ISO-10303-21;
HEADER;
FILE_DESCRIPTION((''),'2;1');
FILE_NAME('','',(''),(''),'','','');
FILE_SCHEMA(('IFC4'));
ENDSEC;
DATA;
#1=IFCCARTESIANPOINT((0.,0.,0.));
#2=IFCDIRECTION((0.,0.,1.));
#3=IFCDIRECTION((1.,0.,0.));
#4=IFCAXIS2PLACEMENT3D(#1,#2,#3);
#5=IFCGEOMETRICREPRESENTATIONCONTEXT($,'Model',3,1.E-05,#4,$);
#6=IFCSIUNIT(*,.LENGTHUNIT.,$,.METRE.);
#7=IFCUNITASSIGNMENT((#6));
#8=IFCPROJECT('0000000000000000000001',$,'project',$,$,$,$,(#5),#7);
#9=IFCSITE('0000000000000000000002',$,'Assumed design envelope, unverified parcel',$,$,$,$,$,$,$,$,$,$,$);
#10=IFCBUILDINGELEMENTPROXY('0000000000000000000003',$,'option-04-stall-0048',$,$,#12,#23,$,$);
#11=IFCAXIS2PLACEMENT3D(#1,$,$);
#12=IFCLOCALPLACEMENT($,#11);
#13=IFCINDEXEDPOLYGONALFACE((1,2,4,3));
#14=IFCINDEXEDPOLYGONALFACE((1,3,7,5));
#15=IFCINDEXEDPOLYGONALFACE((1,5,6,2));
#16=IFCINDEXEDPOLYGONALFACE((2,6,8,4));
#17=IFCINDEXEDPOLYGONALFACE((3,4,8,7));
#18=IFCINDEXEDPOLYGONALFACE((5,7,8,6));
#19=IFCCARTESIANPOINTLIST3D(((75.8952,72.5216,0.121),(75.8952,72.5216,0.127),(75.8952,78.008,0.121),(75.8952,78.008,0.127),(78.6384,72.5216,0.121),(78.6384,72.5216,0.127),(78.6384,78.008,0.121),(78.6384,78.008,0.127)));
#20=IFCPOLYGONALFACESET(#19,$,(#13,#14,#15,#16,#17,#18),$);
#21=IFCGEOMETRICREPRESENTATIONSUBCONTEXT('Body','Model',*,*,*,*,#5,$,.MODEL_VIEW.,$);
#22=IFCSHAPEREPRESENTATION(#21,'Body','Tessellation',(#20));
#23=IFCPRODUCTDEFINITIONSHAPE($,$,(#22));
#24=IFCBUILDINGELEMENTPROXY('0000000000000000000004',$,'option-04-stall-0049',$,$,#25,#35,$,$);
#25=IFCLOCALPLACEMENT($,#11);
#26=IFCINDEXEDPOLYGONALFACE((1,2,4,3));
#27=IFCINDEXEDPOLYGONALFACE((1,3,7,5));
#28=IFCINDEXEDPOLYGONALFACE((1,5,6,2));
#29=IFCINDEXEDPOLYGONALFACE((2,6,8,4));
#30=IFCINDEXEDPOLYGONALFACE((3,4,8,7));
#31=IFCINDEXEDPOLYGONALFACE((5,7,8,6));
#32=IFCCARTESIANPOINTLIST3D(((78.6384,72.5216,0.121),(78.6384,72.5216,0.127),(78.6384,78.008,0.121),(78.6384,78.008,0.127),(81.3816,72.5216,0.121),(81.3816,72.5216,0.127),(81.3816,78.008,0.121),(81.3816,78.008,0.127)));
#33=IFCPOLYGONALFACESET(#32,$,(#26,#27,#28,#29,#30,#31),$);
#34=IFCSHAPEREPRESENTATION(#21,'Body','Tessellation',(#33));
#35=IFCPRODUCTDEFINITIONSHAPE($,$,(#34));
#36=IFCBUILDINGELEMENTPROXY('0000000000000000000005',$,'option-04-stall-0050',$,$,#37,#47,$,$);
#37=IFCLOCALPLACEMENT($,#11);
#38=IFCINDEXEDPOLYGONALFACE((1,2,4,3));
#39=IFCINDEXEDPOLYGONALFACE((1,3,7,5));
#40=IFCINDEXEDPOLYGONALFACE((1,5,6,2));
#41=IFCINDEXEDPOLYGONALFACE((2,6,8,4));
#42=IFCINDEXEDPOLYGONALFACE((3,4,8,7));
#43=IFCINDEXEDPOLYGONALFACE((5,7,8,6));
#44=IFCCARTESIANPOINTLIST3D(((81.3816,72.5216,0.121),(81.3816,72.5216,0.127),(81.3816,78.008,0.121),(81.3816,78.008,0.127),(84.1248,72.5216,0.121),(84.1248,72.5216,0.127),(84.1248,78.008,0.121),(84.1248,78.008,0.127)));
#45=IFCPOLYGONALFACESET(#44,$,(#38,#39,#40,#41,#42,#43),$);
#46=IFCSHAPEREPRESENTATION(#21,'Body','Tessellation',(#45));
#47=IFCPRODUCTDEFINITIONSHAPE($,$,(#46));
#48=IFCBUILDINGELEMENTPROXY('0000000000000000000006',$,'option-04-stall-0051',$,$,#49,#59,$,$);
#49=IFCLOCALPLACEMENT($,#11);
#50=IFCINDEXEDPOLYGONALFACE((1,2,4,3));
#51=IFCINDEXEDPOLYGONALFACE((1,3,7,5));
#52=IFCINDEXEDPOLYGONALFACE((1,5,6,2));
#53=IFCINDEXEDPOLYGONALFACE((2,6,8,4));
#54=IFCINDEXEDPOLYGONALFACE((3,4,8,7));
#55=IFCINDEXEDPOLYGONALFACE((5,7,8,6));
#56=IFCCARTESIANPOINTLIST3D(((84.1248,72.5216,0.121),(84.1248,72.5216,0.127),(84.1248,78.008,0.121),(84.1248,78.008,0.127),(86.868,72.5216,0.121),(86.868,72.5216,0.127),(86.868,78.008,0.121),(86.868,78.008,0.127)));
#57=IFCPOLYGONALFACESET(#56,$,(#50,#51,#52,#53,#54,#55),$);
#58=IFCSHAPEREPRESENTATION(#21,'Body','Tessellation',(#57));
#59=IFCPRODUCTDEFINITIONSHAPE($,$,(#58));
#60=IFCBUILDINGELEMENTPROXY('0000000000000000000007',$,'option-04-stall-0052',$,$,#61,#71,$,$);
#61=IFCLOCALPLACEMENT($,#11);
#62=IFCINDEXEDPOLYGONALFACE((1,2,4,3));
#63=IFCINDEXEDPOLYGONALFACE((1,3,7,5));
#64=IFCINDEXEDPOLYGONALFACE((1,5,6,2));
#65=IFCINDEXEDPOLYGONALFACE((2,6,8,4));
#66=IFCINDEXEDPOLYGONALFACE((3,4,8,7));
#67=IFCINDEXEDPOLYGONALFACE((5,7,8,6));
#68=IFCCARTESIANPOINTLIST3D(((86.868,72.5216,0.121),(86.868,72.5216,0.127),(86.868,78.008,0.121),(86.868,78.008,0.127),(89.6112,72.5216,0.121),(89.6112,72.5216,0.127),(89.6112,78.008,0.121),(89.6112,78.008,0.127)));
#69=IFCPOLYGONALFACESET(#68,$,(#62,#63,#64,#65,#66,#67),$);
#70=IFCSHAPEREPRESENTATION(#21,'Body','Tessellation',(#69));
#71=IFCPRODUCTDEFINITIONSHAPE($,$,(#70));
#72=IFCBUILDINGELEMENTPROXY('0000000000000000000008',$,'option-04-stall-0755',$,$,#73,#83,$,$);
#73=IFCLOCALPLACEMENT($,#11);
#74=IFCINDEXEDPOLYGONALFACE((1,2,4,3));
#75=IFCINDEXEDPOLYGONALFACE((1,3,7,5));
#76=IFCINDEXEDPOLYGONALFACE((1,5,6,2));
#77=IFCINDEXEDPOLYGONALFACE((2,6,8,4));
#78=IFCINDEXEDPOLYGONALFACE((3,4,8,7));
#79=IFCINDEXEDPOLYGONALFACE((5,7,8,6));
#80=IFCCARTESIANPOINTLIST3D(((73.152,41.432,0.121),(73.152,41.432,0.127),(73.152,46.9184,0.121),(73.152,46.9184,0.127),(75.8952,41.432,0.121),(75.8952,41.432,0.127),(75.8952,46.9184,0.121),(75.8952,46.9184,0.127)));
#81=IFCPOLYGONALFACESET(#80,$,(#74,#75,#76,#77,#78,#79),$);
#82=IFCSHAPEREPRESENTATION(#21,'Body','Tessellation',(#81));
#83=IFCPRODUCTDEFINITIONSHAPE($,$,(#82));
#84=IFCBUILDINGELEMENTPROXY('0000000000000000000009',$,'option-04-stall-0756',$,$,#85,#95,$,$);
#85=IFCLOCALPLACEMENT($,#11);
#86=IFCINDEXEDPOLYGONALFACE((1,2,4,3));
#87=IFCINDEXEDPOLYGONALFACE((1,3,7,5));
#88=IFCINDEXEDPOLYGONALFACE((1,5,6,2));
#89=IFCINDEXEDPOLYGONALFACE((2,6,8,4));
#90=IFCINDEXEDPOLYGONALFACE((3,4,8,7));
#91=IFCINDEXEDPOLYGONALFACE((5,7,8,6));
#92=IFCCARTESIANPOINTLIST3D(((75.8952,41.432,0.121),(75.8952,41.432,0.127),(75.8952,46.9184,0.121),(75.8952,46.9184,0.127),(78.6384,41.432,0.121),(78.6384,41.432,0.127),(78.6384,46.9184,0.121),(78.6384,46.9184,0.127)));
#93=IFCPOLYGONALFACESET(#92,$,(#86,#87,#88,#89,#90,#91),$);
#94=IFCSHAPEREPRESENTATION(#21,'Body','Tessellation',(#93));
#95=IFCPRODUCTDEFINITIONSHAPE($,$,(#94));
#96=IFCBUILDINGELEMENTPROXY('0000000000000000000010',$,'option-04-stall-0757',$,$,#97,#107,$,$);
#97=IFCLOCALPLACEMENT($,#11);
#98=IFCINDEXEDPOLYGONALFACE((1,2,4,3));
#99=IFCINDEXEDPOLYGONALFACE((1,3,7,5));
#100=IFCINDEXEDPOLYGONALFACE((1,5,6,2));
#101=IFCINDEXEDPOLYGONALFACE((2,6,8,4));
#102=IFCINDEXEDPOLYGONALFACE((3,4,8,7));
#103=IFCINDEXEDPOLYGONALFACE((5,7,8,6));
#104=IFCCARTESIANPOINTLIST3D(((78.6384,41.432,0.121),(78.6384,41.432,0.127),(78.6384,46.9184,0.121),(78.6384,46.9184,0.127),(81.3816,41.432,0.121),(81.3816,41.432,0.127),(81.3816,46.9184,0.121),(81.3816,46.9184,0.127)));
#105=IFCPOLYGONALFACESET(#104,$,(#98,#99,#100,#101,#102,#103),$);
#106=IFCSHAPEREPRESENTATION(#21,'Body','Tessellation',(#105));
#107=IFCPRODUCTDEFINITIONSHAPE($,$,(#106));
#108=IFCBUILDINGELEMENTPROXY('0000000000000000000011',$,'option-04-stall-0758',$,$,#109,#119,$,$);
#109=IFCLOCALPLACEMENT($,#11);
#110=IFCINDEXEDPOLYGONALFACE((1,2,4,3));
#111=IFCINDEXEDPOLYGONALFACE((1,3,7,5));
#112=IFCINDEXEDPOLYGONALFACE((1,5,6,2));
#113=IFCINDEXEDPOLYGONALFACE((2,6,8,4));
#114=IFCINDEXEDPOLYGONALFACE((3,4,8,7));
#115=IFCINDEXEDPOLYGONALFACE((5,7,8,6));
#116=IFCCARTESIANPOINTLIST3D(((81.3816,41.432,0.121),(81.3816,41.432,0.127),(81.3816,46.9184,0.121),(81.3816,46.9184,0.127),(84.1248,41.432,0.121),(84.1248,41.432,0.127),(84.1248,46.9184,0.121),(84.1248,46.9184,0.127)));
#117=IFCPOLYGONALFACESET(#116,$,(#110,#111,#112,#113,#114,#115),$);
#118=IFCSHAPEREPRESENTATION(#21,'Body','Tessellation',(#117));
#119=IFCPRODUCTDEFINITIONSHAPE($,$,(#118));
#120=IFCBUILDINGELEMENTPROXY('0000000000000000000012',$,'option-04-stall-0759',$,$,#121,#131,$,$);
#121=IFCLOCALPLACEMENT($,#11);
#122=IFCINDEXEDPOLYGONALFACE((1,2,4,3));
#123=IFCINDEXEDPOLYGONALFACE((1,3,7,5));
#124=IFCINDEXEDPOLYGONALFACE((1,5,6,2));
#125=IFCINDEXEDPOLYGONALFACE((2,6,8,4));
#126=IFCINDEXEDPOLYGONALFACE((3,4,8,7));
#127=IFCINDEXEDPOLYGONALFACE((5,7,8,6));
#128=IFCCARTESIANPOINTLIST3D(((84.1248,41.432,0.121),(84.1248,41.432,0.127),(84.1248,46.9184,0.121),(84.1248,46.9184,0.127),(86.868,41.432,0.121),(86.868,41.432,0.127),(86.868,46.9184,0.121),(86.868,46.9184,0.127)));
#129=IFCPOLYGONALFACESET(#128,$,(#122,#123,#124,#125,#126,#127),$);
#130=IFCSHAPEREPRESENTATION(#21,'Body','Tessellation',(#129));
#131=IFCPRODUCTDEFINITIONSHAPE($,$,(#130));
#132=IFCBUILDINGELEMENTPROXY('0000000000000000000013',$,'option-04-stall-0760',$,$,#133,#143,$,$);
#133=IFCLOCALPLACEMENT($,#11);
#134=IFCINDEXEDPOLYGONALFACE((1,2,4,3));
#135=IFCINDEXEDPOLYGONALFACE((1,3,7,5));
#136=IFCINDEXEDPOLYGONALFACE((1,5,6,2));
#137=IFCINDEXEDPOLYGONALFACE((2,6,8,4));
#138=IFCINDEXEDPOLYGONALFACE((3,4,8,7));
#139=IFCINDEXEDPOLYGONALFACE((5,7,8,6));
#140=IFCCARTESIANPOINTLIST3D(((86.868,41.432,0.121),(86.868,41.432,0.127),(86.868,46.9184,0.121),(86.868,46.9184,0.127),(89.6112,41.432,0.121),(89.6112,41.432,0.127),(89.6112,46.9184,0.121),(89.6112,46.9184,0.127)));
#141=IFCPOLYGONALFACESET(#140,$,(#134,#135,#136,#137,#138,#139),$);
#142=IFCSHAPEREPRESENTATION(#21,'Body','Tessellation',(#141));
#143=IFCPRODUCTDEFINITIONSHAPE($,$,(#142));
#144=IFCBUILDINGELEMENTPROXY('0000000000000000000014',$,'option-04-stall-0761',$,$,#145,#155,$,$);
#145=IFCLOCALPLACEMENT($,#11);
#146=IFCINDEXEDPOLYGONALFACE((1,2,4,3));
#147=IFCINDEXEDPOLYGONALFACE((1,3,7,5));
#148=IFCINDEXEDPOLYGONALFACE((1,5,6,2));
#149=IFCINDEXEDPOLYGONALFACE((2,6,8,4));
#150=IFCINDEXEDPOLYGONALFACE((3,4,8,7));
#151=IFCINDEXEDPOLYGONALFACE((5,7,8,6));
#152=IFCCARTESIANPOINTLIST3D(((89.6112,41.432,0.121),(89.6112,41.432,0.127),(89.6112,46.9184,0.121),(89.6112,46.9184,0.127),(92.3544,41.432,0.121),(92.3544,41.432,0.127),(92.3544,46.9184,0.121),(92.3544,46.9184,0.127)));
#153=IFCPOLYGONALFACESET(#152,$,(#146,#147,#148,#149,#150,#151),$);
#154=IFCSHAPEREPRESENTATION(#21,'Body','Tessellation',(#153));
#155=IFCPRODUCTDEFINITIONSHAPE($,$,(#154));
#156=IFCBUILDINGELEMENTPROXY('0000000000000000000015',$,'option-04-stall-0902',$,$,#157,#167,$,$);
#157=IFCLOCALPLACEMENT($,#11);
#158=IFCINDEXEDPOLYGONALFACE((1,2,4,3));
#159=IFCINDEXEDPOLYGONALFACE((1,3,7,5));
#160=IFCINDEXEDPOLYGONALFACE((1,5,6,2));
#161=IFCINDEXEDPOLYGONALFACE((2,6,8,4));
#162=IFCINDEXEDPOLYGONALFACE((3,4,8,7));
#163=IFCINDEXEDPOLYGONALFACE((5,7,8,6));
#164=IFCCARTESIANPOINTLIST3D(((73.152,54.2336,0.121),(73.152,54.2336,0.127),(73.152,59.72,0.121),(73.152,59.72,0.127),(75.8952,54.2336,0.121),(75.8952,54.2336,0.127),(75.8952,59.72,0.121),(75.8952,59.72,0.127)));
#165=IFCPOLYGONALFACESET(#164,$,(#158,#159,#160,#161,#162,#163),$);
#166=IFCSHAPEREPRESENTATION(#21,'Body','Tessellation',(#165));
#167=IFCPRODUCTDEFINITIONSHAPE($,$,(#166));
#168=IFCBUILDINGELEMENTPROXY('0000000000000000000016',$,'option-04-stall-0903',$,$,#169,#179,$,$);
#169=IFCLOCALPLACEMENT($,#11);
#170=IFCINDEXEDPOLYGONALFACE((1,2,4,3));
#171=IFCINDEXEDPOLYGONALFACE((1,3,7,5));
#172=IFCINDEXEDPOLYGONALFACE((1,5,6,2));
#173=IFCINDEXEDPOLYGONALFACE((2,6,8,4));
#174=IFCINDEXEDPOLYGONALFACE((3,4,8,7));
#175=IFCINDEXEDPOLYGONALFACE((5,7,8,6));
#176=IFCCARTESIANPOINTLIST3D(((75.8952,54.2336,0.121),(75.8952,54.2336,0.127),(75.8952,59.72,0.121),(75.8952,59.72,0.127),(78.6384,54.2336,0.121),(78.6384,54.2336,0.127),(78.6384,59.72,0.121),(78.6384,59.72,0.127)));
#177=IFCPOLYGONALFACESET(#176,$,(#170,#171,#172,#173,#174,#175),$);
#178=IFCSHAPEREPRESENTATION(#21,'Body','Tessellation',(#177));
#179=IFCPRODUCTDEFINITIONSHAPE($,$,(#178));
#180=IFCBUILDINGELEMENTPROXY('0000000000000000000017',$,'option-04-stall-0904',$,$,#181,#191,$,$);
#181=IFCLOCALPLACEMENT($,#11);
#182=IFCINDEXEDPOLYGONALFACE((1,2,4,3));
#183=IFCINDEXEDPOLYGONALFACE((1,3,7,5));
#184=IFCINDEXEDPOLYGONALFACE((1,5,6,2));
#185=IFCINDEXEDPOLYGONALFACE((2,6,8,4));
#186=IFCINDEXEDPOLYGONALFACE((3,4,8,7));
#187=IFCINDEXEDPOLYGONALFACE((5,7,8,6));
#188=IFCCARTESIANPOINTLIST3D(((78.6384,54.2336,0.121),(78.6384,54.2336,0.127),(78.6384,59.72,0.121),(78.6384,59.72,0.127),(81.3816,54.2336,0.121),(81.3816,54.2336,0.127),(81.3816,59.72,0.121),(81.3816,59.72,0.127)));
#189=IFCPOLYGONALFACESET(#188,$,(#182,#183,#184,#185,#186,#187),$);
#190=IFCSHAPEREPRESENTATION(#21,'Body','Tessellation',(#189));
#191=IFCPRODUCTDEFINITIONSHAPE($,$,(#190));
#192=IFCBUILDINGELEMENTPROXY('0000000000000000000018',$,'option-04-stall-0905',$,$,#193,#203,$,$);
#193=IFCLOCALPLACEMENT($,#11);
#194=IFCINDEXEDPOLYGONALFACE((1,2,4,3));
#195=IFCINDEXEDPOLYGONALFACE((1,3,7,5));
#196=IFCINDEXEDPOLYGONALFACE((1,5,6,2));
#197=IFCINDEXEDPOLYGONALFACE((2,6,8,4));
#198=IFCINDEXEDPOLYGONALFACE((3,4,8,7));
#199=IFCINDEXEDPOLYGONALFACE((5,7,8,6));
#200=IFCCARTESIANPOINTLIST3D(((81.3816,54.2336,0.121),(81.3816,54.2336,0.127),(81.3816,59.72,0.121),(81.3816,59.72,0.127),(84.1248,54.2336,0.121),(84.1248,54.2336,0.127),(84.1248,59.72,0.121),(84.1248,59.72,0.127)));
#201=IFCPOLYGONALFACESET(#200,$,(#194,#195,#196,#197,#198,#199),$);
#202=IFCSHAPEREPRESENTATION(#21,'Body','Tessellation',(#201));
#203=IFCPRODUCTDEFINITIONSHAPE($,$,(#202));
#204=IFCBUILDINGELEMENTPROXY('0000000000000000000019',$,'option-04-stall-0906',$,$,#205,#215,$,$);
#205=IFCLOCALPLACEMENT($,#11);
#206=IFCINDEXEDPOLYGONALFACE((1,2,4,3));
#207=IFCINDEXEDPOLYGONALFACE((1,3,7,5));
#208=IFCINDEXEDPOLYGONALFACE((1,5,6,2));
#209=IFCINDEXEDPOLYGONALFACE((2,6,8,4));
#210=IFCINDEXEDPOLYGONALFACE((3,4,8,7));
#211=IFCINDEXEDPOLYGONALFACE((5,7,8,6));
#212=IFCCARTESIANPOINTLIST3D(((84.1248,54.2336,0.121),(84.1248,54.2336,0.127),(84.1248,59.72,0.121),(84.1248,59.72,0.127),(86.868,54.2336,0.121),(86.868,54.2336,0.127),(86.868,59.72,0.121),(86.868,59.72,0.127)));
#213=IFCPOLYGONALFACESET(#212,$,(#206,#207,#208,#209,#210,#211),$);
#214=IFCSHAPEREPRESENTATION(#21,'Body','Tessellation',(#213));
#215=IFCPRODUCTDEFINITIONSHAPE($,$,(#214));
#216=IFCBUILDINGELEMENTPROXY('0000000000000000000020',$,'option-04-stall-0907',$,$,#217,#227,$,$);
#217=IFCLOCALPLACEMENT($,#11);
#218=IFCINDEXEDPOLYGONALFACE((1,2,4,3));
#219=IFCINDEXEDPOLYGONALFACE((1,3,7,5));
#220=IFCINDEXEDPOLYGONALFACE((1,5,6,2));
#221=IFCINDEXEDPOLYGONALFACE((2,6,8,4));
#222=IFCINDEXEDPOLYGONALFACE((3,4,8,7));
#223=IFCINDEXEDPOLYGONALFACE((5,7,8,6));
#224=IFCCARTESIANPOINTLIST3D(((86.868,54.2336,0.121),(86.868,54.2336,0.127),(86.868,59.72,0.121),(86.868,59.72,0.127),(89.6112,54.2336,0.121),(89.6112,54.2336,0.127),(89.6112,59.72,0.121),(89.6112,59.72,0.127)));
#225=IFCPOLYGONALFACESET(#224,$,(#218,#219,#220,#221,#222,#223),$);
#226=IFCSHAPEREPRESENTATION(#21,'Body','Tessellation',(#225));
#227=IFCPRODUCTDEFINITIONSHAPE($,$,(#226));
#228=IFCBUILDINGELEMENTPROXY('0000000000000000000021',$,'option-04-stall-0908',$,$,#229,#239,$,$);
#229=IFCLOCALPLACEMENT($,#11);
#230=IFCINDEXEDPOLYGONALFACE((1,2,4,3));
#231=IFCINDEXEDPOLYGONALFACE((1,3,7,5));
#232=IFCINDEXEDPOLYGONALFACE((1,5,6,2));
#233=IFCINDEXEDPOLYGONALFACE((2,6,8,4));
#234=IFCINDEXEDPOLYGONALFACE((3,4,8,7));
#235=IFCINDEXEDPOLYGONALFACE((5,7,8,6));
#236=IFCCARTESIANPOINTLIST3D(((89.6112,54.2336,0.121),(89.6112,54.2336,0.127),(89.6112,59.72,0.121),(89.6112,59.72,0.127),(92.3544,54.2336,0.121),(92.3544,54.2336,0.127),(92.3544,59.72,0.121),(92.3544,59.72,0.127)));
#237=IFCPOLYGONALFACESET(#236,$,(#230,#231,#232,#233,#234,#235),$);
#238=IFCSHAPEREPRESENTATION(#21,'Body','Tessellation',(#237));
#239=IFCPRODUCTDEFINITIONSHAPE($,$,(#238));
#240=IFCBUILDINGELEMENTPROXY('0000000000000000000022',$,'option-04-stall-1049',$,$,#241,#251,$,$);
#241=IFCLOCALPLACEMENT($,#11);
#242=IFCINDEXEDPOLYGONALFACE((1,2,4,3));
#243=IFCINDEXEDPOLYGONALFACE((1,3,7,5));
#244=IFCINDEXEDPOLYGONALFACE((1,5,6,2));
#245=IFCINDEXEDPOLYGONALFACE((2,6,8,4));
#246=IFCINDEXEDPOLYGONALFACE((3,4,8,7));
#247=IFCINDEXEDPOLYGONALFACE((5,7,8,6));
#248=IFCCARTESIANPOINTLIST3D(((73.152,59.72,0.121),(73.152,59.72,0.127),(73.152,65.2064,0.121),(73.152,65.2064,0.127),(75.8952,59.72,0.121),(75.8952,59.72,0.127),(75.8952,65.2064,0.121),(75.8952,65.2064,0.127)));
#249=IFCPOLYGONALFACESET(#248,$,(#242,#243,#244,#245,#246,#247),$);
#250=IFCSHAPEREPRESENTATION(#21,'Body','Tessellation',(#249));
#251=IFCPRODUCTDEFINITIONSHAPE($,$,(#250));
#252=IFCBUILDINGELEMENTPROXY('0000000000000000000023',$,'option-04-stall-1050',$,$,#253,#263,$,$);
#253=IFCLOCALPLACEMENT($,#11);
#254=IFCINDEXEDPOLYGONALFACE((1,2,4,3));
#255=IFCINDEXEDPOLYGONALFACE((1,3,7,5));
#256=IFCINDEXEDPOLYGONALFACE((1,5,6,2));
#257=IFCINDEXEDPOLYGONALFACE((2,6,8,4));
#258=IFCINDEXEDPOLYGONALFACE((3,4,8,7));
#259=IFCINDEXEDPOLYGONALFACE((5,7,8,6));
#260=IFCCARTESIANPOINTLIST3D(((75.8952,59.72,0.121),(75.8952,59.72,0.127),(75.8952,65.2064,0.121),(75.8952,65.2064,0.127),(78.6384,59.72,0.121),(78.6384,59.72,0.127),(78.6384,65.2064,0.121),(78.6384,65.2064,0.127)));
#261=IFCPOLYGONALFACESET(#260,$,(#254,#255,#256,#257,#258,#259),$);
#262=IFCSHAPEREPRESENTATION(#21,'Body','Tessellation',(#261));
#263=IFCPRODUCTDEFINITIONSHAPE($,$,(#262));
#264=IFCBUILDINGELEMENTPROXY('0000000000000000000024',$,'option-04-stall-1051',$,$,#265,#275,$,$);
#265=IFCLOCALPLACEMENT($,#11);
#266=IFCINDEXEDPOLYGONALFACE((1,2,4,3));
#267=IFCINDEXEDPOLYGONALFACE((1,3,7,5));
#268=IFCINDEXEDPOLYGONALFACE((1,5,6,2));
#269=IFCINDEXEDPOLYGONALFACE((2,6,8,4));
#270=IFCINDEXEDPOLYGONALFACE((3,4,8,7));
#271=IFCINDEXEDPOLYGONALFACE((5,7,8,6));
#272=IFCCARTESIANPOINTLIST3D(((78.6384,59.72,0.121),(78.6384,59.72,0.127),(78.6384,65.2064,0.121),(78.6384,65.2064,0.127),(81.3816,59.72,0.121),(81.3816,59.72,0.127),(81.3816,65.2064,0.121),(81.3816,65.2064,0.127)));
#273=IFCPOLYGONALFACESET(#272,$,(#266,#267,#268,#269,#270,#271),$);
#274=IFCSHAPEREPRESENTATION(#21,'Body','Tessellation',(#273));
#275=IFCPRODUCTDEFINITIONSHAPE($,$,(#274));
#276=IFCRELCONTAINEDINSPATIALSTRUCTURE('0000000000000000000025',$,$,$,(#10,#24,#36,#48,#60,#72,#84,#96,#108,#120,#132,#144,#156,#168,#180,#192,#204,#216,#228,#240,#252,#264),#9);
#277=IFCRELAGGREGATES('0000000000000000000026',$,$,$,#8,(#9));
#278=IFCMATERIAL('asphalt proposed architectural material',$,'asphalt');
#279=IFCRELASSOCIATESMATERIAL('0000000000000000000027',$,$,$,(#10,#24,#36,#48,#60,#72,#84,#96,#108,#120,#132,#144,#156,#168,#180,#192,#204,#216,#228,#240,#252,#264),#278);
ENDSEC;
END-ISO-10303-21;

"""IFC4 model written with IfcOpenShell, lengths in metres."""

from ifc_helpers import new_model, si_unit, frame, origin_with_axes, place, context, subcontext, project, spatial, rectangle, extrude, material, element, save


model = new_model("IFC4")

# Units and contexts
model_context = context("Model", 3, precision=1e-05, world=origin_with_axes())
body_context = subcontext(model_context, "Body", "Model", "MODEL_VIEW")
ifc_project = project(units=[si_unit("LENGTHUNIT", "METRE")], contexts=[model_context])

# Site
site = spatial("IfcSite", under=ifc_project, Name="Assumed design envelope, unverified parcel")

# Building element proxies
ifc_material = material(Name="asphalt proposed architectural material", Category="asphalt")
for number, where, z_axis, x_axis, name in (
    (1, (77.2668, 75.2648, 0.121), (0.0, 0.0, 1.0), (1.0, 0.0, 0.0), "option-04-stall-0048"),
    (2, (80.01, 75.2648, 0.121), (0.0, 0.0, 1.0), (1.0, 0.0, 0.0), "option-04-stall-0049"),
    (3, (82.7532, 75.2648, 0.121), (0.0, 0.0, 1.0), (1.0, 0.0, 0.0), "option-04-stall-0050"),
    (4, (85.4964, 75.2648, 0.121), (0.0, 0.0, 1.0), (1.0, 0.0, 0.0), "option-04-stall-0051"),
    (5, (88.2396, 75.2648, 0.121), (0.0, 0.0, 1.0), (1.0, 0.0, 0.0), "option-04-stall-0052"),
    (6, (74.5236, 44.1752, 0.121), (0.0, 0.0, 1.0), (1.0, 0.0, 0.0), "option-04-stall-0755"),
    (7, (77.2668, 44.1752, 0.121), (0.0, 0.0, 1.0), (1.0, 0.0, 0.0), "option-04-stall-0756"),
    (8, (80.01, 44.1752, 0.121), (0.0, 0.0, 1.0), (1.0, 0.0, 0.0), "option-04-stall-0757"),
    (9, (82.7532, 44.1752, 0.121), (0.0, 0.0, 1.0), (1.0, 0.0, 0.0), "option-04-stall-0758"),
    (10, (85.4964, 44.1752, 0.121), (0.0, 0.0, 1.0), (1.0, 0.0, 0.0), "option-04-stall-0759"),
    (11, (88.2396, 44.1752, 0.121), (0.0, 0.0, 1.0), (1.0, 0.0, 0.0), "option-04-stall-0760"),
    (12, (90.9828, 44.1752, 0.121), (0.0, 0.0, 1.0), (1.0, 0.0, 0.0), "option-04-stall-0761"),
    (13, (74.5236, 56.9768, 0.121), (0.0, 0.0, 1.0), (1.0, 0.0, 0.0), "option-04-stall-0902"),
    (14, (77.2668, 56.9768, 0.121), (0.0, 0.0, 1.0), (1.0, 0.0, 0.0), "option-04-stall-0903"),
    (15, (80.01, 56.9768, 0.121), (0.0, 0.0, 1.0), (1.0, 0.0, 0.0), "option-04-stall-0904"),
    (16, (82.7532, 56.9768, 0.121), (0.0, 0.0, 1.0), (1.0, 0.0, 0.0), "option-04-stall-0905"),
    (17, (85.4964, 56.9768, 0.121), (0.0, 0.0, 1.0), (1.0, 0.0, 0.0), "option-04-stall-0906"),
    (18, (88.2396, 56.9768, 0.121), (0.0, 0.0, 1.0), (1.0, 0.0, 0.0), "option-04-stall-0907"),
    (19, (90.9828, 56.9768, 0.121), (0.0, 0.0, 1.0), (1.0, 0.0, 0.0), "option-04-stall-0908"),
    (20, (74.5236, 62.4632, 0.121), (0.0, 0.0, 1.0), (1.0, 0.0, 0.0), "option-04-stall-1049"),
    (21, (77.2668, 62.4632, 0.121), (0.0, 0.0, 1.0), (1.0, 0.0, 0.0), "option-04-stall-1050"),
    (22, (80.01, 62.4632, 0.121), (0.0, 0.0, 1.0), (1.0, 0.0, 0.0), "option-04-stall-1051"),
):
    element("IfcBuildingElementProxy", number, at=place(None, frame(where, z_axis=z_axis, x_axis=x_axis)), inside=site, material=ifc_material, Name=name, context=body_context, shape_type="SweptSolid", body=[
        extrude(rectangle(XDim=2.7432, YDim=5.4864), origin_with_axes(), (0.0, 0.0, 1.0), 0.006),
    ])

save(model, "model.ifc")
